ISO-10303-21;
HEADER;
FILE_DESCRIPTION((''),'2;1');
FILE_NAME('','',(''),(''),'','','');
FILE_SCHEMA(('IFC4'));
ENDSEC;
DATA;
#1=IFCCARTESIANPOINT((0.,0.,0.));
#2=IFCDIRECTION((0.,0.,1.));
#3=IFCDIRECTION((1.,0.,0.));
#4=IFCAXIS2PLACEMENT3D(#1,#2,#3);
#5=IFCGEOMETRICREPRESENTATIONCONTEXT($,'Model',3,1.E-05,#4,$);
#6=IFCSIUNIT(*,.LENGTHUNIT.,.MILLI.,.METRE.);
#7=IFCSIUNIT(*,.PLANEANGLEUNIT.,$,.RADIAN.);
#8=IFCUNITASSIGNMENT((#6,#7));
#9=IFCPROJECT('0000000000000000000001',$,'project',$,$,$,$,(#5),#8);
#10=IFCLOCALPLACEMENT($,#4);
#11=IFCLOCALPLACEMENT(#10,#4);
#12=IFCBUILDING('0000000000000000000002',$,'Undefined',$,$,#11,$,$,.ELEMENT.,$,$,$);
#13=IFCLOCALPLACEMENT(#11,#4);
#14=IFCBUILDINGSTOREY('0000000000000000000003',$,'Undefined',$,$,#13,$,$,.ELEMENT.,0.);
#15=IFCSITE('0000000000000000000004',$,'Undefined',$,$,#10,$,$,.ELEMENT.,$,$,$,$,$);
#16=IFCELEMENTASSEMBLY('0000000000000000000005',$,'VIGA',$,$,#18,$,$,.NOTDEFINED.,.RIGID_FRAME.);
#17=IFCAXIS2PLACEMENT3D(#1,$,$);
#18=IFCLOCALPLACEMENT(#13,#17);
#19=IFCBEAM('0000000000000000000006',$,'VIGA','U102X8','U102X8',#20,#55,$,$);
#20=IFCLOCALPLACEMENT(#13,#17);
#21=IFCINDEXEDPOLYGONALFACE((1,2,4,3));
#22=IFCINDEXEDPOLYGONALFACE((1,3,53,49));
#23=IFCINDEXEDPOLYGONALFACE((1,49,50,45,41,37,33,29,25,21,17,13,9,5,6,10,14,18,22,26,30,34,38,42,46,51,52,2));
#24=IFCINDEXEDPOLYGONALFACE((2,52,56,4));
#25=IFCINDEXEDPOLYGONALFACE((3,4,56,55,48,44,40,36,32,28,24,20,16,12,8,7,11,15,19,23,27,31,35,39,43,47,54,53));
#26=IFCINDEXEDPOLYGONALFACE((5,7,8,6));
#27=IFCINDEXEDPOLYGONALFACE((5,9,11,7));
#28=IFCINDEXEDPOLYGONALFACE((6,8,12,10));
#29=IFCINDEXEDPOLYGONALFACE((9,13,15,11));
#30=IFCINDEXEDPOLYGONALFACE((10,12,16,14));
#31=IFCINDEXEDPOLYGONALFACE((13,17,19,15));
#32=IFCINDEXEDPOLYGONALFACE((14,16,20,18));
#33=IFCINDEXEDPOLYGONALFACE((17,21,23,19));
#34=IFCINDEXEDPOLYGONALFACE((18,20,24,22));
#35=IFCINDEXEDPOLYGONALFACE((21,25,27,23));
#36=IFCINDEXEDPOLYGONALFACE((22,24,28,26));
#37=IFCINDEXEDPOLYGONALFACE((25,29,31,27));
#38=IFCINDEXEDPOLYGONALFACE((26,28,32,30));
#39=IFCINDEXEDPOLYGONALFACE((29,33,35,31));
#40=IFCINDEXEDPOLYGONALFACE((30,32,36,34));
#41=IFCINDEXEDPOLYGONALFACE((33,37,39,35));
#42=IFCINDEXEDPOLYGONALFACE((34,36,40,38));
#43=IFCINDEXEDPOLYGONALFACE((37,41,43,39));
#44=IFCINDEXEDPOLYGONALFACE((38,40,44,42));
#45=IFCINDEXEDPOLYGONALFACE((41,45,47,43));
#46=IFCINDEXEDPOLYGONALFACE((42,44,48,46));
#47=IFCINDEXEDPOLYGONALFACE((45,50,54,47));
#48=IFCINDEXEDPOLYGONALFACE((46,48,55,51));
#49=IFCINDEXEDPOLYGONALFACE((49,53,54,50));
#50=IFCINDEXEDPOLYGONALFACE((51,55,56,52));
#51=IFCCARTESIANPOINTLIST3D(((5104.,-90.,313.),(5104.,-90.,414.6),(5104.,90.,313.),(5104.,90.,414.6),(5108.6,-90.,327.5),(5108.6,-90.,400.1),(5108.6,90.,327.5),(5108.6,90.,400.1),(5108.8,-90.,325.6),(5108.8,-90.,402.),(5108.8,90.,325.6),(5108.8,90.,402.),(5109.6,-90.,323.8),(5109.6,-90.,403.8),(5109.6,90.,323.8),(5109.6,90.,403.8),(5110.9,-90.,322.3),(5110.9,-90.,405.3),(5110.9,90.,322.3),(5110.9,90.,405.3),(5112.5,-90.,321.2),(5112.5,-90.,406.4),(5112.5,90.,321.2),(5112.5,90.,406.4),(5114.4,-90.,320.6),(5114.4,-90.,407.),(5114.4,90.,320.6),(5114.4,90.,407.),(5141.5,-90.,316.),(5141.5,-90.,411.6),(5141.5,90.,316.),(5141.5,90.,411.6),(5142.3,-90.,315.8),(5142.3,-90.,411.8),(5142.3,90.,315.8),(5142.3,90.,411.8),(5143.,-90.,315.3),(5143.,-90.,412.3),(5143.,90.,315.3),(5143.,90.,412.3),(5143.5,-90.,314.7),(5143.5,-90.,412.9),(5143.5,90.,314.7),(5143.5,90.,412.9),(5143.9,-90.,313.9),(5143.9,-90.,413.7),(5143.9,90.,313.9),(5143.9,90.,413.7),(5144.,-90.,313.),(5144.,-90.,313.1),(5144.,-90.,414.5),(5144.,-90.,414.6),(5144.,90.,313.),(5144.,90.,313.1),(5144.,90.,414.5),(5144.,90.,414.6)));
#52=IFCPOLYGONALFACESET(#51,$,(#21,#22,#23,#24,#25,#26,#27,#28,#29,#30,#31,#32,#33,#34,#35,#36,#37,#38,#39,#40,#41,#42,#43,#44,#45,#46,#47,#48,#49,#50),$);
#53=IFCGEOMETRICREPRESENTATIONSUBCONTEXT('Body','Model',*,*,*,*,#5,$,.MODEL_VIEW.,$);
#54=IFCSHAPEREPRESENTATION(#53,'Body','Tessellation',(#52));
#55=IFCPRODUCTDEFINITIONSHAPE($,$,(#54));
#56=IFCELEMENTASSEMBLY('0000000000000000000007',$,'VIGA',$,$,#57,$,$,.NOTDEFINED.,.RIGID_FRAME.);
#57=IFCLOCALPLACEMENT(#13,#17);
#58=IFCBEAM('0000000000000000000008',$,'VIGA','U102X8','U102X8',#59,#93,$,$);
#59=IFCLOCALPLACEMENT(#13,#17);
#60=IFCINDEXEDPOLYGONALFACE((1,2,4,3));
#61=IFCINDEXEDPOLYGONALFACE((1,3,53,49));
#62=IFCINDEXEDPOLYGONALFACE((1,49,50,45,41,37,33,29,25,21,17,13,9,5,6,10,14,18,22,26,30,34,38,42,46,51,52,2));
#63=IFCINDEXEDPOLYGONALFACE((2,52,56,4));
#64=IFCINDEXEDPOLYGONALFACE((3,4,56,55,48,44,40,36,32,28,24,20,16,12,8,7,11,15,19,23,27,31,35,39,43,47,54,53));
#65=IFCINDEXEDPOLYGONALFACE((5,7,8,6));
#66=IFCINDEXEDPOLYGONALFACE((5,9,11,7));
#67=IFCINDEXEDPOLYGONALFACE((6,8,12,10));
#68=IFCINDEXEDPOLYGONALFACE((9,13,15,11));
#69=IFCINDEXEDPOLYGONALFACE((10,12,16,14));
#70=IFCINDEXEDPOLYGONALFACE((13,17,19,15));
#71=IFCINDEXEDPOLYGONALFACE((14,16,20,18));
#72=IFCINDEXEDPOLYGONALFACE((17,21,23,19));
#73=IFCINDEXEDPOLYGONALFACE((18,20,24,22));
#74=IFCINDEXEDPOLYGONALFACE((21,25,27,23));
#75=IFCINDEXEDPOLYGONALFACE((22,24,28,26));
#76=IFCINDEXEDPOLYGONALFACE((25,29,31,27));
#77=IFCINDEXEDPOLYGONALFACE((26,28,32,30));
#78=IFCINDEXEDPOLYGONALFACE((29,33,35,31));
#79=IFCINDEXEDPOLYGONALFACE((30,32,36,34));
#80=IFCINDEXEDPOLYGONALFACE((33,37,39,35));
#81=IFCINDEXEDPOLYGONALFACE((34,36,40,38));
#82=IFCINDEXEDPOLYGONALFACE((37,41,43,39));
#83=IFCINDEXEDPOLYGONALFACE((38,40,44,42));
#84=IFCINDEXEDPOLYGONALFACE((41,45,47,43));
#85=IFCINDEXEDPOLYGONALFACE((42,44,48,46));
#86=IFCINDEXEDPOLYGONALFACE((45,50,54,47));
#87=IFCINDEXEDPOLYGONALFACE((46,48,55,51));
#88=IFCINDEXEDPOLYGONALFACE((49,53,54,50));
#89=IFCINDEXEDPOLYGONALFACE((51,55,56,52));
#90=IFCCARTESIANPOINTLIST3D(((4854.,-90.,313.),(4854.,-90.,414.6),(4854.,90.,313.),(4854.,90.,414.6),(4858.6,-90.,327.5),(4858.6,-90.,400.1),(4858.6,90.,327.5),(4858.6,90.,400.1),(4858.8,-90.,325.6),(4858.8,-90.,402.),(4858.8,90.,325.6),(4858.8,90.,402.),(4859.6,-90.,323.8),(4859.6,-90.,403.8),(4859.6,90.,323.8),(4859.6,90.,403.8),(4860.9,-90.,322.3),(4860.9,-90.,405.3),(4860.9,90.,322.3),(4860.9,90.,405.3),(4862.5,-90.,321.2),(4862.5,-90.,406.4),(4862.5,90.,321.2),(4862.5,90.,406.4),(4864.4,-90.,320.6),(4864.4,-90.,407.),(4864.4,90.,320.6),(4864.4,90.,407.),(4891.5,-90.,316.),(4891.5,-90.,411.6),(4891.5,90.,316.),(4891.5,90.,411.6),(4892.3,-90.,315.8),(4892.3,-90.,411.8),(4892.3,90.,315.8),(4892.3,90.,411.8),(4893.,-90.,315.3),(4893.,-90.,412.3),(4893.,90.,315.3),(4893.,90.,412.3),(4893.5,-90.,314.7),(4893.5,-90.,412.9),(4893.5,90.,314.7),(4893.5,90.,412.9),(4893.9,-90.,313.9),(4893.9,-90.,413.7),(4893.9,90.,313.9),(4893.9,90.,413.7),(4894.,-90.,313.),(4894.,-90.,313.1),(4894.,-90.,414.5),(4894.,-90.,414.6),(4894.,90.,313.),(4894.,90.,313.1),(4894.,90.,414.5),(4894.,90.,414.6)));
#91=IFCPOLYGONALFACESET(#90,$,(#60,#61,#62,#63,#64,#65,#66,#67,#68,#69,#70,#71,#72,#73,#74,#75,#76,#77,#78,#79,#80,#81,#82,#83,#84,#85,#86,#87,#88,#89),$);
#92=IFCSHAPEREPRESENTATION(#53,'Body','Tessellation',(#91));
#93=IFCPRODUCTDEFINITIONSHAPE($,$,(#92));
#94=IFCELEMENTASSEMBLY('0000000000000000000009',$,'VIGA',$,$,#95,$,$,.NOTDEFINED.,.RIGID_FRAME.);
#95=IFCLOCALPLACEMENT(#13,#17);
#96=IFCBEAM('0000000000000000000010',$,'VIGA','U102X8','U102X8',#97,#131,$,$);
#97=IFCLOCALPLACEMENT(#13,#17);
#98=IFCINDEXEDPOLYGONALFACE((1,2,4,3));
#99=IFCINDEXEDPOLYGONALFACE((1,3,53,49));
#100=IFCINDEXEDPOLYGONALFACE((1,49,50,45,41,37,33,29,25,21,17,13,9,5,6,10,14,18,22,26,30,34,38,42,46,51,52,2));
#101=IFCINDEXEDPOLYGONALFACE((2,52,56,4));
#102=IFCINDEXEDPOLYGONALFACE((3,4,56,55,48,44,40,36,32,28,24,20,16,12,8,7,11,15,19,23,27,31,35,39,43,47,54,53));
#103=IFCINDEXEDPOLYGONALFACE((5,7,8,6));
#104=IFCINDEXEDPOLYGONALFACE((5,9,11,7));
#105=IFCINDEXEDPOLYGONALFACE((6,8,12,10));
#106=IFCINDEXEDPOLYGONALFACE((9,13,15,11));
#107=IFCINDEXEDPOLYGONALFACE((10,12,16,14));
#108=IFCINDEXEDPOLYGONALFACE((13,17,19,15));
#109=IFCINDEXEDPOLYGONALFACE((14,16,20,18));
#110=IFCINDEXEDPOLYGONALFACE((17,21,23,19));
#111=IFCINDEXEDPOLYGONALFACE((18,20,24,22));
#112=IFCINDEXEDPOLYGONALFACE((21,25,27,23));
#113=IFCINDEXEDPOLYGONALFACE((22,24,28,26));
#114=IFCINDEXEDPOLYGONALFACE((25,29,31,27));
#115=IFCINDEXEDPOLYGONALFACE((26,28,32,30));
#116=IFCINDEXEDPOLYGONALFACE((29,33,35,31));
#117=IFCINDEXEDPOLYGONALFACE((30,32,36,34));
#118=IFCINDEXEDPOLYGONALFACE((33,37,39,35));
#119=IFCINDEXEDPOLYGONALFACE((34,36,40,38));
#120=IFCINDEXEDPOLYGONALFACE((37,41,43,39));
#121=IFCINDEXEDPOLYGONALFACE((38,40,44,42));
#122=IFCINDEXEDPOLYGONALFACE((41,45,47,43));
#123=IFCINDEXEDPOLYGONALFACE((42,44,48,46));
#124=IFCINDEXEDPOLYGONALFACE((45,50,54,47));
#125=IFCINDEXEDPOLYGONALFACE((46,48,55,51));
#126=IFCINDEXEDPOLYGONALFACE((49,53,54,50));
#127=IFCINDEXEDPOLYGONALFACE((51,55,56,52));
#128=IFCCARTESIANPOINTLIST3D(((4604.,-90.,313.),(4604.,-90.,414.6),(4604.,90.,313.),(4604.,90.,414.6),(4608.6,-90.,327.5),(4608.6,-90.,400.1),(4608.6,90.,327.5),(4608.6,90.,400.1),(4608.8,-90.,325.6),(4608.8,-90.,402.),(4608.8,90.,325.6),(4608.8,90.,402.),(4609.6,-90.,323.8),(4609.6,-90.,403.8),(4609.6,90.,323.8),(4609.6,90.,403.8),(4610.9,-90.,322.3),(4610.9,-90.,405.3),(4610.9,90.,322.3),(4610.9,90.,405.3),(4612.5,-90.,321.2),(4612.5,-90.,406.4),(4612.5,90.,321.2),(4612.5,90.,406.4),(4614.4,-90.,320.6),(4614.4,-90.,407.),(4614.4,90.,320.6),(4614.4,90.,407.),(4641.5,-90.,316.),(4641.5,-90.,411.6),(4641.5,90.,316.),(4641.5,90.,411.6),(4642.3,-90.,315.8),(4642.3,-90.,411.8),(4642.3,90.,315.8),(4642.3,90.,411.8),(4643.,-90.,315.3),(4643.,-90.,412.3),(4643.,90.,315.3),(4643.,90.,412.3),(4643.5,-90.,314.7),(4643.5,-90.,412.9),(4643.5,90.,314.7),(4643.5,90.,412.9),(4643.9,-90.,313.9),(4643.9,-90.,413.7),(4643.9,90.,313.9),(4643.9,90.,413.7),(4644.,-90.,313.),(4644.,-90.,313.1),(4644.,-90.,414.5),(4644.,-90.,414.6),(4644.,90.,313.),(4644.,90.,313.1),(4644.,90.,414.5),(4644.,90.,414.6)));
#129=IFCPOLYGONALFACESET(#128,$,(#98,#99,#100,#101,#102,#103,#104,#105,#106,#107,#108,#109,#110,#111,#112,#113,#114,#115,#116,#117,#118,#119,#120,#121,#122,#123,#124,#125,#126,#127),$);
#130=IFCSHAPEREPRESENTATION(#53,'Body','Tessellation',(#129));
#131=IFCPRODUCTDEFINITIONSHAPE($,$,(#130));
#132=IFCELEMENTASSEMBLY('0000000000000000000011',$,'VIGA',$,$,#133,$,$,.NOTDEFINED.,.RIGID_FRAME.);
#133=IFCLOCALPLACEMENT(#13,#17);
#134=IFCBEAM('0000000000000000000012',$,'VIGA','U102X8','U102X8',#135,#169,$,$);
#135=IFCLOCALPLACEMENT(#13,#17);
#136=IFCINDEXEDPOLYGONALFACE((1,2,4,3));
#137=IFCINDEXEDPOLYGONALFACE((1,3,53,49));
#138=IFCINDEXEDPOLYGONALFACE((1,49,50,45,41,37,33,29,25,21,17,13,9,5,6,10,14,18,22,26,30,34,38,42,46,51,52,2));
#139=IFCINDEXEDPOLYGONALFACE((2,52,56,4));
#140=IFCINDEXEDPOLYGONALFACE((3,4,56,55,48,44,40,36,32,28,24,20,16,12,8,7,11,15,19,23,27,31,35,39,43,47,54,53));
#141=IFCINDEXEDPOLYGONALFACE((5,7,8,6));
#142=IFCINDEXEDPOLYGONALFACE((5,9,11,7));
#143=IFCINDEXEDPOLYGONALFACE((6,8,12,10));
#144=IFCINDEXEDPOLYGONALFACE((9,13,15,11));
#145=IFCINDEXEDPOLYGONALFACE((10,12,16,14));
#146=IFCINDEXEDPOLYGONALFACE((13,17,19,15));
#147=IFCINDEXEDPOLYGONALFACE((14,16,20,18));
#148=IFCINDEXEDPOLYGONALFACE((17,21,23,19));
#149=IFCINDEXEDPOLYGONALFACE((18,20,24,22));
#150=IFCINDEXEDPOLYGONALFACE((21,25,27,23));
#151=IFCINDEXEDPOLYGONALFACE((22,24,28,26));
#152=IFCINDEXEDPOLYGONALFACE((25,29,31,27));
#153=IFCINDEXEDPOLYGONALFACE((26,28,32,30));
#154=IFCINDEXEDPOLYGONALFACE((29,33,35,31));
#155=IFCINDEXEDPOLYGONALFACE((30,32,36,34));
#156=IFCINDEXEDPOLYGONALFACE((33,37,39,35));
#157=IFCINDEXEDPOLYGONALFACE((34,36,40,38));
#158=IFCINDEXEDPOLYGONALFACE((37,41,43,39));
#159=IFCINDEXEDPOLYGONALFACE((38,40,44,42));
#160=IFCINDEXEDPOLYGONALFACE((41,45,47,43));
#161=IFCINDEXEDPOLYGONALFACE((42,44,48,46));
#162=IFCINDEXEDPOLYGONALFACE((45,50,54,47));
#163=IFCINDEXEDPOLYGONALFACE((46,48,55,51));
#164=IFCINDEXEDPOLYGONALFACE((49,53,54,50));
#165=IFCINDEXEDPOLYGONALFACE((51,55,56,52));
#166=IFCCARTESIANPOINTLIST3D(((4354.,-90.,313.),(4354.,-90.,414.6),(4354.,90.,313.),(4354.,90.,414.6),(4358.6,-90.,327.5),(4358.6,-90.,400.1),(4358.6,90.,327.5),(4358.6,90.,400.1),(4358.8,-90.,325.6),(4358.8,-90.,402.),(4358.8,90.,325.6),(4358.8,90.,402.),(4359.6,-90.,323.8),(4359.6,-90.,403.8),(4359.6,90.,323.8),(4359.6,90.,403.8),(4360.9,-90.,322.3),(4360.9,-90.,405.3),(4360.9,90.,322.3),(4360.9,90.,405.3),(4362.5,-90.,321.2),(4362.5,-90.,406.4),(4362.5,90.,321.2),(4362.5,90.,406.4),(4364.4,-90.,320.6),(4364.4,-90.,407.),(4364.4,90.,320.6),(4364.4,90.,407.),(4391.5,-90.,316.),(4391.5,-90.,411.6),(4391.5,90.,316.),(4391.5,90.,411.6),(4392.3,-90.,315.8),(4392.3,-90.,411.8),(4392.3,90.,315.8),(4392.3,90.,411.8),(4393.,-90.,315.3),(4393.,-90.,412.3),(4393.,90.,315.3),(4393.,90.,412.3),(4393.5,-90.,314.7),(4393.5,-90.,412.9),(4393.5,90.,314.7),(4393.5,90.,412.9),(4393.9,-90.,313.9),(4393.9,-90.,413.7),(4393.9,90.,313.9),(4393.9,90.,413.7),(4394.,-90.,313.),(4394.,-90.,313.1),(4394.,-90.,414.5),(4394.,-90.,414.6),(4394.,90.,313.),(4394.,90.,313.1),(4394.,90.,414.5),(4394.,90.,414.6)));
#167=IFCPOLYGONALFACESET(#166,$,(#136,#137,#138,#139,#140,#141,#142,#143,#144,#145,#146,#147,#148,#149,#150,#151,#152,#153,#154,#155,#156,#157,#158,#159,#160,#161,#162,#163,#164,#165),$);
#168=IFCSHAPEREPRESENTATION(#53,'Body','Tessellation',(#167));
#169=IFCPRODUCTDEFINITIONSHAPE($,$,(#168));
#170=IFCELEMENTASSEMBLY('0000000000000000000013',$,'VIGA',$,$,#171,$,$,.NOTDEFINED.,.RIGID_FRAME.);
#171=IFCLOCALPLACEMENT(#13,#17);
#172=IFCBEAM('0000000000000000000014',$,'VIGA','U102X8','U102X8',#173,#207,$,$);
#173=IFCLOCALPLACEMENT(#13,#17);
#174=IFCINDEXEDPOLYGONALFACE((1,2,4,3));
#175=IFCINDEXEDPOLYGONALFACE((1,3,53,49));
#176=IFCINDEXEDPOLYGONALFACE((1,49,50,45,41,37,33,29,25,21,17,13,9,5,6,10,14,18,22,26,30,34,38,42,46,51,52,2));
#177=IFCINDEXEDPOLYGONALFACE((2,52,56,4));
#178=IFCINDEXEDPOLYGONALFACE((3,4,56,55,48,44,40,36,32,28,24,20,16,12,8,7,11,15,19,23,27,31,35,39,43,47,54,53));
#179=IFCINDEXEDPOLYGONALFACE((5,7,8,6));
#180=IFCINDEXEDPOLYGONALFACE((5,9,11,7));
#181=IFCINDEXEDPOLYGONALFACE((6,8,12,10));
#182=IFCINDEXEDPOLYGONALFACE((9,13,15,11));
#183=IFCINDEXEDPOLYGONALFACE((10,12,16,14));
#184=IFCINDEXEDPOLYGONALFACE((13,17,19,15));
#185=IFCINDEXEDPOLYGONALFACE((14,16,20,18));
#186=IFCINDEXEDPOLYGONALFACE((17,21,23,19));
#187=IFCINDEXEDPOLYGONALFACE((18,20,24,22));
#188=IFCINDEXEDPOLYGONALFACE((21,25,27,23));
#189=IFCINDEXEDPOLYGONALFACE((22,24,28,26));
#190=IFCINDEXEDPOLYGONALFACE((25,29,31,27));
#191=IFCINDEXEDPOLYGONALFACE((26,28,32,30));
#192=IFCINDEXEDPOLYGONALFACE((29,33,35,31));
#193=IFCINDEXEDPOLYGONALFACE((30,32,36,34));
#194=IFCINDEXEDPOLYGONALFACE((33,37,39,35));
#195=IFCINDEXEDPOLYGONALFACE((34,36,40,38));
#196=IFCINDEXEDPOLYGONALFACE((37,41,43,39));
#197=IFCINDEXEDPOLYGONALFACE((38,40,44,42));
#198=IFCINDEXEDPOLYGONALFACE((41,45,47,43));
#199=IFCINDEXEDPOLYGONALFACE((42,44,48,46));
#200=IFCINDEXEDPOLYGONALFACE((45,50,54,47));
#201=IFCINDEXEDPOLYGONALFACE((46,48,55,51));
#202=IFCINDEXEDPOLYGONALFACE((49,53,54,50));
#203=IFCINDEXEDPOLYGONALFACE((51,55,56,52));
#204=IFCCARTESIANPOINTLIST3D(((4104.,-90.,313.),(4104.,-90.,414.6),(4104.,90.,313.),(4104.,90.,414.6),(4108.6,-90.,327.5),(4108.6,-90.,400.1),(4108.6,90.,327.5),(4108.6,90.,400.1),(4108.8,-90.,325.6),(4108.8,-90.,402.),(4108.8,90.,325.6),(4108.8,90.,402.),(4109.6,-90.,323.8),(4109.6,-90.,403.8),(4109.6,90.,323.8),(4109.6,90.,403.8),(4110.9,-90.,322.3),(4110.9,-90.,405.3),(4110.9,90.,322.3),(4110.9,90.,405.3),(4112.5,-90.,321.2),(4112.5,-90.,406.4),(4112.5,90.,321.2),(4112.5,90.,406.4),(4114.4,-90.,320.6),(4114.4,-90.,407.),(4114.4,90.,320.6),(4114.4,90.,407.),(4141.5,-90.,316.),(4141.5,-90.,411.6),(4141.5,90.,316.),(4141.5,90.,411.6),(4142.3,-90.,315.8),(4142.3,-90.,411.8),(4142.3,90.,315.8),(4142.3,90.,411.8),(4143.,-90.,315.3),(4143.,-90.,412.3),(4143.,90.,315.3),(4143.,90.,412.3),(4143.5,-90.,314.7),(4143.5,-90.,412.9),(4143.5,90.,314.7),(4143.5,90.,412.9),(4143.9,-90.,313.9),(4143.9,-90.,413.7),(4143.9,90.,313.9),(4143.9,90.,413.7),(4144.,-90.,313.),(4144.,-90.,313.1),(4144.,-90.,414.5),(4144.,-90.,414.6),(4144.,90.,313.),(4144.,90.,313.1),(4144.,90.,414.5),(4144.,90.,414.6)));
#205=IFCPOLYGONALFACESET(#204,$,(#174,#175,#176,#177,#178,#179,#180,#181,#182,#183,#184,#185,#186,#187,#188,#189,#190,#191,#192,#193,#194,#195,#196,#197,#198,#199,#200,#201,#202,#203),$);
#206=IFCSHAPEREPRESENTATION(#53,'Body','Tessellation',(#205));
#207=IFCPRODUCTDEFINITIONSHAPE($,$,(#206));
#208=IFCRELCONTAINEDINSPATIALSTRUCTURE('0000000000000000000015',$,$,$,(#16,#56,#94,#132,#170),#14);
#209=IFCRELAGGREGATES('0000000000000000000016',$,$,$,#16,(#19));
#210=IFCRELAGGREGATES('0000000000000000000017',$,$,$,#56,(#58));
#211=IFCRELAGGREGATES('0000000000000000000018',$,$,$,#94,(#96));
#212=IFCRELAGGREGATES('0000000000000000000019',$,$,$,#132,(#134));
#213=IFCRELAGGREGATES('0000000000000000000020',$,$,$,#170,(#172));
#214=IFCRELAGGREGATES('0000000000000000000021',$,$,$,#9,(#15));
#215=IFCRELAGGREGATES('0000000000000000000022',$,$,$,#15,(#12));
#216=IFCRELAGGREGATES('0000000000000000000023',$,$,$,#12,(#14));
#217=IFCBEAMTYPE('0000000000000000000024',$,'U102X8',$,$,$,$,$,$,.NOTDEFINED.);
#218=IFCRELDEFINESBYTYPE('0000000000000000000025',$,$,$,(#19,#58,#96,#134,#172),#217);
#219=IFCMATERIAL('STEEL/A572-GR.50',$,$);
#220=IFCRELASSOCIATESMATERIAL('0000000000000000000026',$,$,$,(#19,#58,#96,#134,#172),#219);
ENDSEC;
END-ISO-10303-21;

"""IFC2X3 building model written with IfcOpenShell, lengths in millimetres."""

from ifc_helpers import new_model, si_unit, frame, origin_with_axes, origin_2d_with_axis, place, context, subcontext, project, spatial, u_section, extrude, material, type_object, element, aggregate, save


model = new_model("IFC2X3")

# Units and contexts
model_context = context("Model", 3, precision=1e-05, world=origin_with_axes())
body_context = subcontext(model_context, "Body", "Model", "MODEL_VIEW")
ifc_project = project(units=[si_unit("LENGTHUNIT", "METRE", prefix="MILLI"), si_unit("PLANEANGLEUNIT", "RADIAN")], contexts=[model_context])

# Site, building, storey
site_placement = place(None, origin_with_axes())
site = spatial("IfcSite", under=ifc_project, at=site_placement, Name="Undefined", CompositionType="ELEMENT")
building_placement = place(site_placement, origin_with_axes())
building = spatial("IfcBuilding", under=site, at=building_placement, Name="Undefined", CompositionType="ELEMENT")
storey_placement = place(building_placement, origin_with_axes())
storey = spatial("IfcBuildingStorey", under=building, at=storey_placement, Name="Undefined", CompositionType="ELEMENT", Elevation=0.0)

# Element assemblies, beams
ifc_material_1 = material(Name="STEEL/A572-GR.50")
beam_type_1 = type_object("IfcBeamType", Name="U102X8", PredefinedType="NOTDEFINED")
assembly_1_placement = place(storey_placement, origin_with_axes())
assembly_1 = element("IfcElementAssembly", 1, at=assembly_1_placement, inside=storey, Name="VIGA", AssemblyPlace="NOTDEFINED", PredefinedType="RIGID_FRAME")
beam_1_placement = place(assembly_1_placement, frame((5124.0, -90.0, 363.8), z_axis=(0.0, 0.0, 1.0), x_axis=(0.0, 1.0, 0.0)))
beam_1 = element("IfcBeam", 2, at=beam_1_placement, type_object=beam_type_1, material=ifc_material_1, Name="VIGA", Description="U102X8", ObjectType="U102X8", context=body_context, shape_type="SweptSolid", body=[
    extrude(u_section(Depth=101.6, FlangeWidth=40.0, WebThickness=4.6, FlangeThickness=6.0, FilletRadius=7.0, EdgeRadius=3.0, FlangeSlope=0.16839, at=origin_2d_with_axis()), frame((180.0, 0.0, 0.0), z_axis=(-1.0, 0.0, 0.0), x_axis=(0.0, -1.0, 0.0)), (0.0, 0.0, 1.0), 180.0),
])
aggregate(assembly_1, [beam_1])
assembly_2_placement = place(storey_placement, origin_with_axes())
assembly_2 = element("IfcElementAssembly", 3, at=assembly_2_placement, inside=storey, Name="VIGA", AssemblyPlace="NOTDEFINED", PredefinedType="RIGID_FRAME")
beam_2_placement = place(assembly_2_placement, frame((4874.0, -90.0, 363.8), z_axis=(0.0, 0.0, 1.0), x_axis=(0.0, 1.0, 0.0)))
beam_2 = element("IfcBeam", 4, at=beam_2_placement, type_object=beam_type_1, material=ifc_material_1, Name="VIGA", Description="U102X8", ObjectType="U102X8", context=body_context, shape_type="SweptSolid", body=[
    extrude(u_section(Depth=101.6, FlangeWidth=40.0, WebThickness=4.6, FlangeThickness=6.0, FilletRadius=7.0, EdgeRadius=3.0, FlangeSlope=0.16839, at=origin_2d_with_axis()), frame((180.0, 0.0, 0.0), z_axis=(-1.0, 0.0, 0.0), x_axis=(0.0, -1.0, 0.0)), (0.0, 0.0, 1.0), 180.0),
])
aggregate(assembly_2, [beam_2])
assembly_3_placement = place(storey_placement, origin_with_axes())
assembly_3 = element("IfcElementAssembly", 5, at=assembly_3_placement, inside=storey, Name="VIGA", AssemblyPlace="NOTDEFINED", PredefinedType="RIGID_FRAME")
beam_3_placement = place(assembly_3_placement, frame((4624.0, -90.0, 363.8), z_axis=(0.0, 0.0, 1.0), x_axis=(0.0, 1.0, 0.0)))
beam_3 = element("IfcBeam", 6, at=beam_3_placement, type_object=beam_type_1, material=ifc_material_1, Name="VIGA", Description="U102X8", ObjectType="U102X8", context=body_context, shape_type="SweptSolid", body=[
    extrude(u_section(Depth=101.6, FlangeWidth=40.0, WebThickness=4.6, FlangeThickness=6.0, FilletRadius=7.0, EdgeRadius=3.0, FlangeSlope=0.16839, at=origin_2d_with_axis()), frame((180.0, 0.0, 0.0), z_axis=(-1.0, 0.0, 0.0), x_axis=(0.0, -1.0, 0.0)), (0.0, 0.0, 1.0), 180.0),
])
aggregate(assembly_3, [beam_3])
assembly_4_placement = place(storey_placement, origin_with_axes())
assembly_4 = element("IfcElementAssembly", 7, at=assembly_4_placement, inside=storey, Name="VIGA", AssemblyPlace="NOTDEFINED", PredefinedType="RIGID_FRAME")
beam_4_placement = place(assembly_4_placement, frame((4374.0, -90.0, 363.8), z_axis=(0.0, 0.0, 1.0), x_axis=(0.0, 1.0, 0.0)))
beam_4 = element("IfcBeam", 8, at=beam_4_placement, type_object=beam_type_1, material=ifc_material_1, Name="VIGA", Description="U102X8", ObjectType="U102X8", context=body_context, shape_type="SweptSolid", body=[
    extrude(u_section(Depth=101.6, FlangeWidth=40.0, WebThickness=4.6, FlangeThickness=6.0, FilletRadius=7.0, EdgeRadius=3.0, FlangeSlope=0.16839, at=origin_2d_with_axis()), frame((180.0, 0.0, 0.0), z_axis=(-1.0, 0.0, 0.0), x_axis=(0.0, -1.0, 0.0)), (0.0, 0.0, 1.0), 180.0),
])
aggregate(assembly_4, [beam_4])
assembly_5_placement = place(storey_placement, origin_with_axes())
assembly_5 = element("IfcElementAssembly", 9, at=assembly_5_placement, inside=storey, Name="VIGA", AssemblyPlace="NOTDEFINED", PredefinedType="RIGID_FRAME")
beam_5_placement = place(assembly_5_placement, frame((4124.0, -90.0, 363.8), z_axis=(0.0, 0.0, 1.0), x_axis=(0.0, 1.0, 0.0)))
beam_5 = element("IfcBeam", 10, at=beam_5_placement, type_object=beam_type_1, material=ifc_material_1, Name="VIGA", Description="U102X8", ObjectType="U102X8", context=body_context, shape_type="SweptSolid", body=[
    extrude(u_section(Depth=101.6, FlangeWidth=40.0, WebThickness=4.6, FlangeThickness=6.0, FilletRadius=7.0, EdgeRadius=3.0, FlangeSlope=0.16839, at=origin_2d_with_axis()), frame((180.0, 0.0, 0.0), z_axis=(-1.0, 0.0, 0.0), x_axis=(0.0, -1.0, 0.0)), (0.0, 0.0, 1.0), 180.0),
])
aggregate(assembly_5, [beam_5])

save(model, "model.ifc")
